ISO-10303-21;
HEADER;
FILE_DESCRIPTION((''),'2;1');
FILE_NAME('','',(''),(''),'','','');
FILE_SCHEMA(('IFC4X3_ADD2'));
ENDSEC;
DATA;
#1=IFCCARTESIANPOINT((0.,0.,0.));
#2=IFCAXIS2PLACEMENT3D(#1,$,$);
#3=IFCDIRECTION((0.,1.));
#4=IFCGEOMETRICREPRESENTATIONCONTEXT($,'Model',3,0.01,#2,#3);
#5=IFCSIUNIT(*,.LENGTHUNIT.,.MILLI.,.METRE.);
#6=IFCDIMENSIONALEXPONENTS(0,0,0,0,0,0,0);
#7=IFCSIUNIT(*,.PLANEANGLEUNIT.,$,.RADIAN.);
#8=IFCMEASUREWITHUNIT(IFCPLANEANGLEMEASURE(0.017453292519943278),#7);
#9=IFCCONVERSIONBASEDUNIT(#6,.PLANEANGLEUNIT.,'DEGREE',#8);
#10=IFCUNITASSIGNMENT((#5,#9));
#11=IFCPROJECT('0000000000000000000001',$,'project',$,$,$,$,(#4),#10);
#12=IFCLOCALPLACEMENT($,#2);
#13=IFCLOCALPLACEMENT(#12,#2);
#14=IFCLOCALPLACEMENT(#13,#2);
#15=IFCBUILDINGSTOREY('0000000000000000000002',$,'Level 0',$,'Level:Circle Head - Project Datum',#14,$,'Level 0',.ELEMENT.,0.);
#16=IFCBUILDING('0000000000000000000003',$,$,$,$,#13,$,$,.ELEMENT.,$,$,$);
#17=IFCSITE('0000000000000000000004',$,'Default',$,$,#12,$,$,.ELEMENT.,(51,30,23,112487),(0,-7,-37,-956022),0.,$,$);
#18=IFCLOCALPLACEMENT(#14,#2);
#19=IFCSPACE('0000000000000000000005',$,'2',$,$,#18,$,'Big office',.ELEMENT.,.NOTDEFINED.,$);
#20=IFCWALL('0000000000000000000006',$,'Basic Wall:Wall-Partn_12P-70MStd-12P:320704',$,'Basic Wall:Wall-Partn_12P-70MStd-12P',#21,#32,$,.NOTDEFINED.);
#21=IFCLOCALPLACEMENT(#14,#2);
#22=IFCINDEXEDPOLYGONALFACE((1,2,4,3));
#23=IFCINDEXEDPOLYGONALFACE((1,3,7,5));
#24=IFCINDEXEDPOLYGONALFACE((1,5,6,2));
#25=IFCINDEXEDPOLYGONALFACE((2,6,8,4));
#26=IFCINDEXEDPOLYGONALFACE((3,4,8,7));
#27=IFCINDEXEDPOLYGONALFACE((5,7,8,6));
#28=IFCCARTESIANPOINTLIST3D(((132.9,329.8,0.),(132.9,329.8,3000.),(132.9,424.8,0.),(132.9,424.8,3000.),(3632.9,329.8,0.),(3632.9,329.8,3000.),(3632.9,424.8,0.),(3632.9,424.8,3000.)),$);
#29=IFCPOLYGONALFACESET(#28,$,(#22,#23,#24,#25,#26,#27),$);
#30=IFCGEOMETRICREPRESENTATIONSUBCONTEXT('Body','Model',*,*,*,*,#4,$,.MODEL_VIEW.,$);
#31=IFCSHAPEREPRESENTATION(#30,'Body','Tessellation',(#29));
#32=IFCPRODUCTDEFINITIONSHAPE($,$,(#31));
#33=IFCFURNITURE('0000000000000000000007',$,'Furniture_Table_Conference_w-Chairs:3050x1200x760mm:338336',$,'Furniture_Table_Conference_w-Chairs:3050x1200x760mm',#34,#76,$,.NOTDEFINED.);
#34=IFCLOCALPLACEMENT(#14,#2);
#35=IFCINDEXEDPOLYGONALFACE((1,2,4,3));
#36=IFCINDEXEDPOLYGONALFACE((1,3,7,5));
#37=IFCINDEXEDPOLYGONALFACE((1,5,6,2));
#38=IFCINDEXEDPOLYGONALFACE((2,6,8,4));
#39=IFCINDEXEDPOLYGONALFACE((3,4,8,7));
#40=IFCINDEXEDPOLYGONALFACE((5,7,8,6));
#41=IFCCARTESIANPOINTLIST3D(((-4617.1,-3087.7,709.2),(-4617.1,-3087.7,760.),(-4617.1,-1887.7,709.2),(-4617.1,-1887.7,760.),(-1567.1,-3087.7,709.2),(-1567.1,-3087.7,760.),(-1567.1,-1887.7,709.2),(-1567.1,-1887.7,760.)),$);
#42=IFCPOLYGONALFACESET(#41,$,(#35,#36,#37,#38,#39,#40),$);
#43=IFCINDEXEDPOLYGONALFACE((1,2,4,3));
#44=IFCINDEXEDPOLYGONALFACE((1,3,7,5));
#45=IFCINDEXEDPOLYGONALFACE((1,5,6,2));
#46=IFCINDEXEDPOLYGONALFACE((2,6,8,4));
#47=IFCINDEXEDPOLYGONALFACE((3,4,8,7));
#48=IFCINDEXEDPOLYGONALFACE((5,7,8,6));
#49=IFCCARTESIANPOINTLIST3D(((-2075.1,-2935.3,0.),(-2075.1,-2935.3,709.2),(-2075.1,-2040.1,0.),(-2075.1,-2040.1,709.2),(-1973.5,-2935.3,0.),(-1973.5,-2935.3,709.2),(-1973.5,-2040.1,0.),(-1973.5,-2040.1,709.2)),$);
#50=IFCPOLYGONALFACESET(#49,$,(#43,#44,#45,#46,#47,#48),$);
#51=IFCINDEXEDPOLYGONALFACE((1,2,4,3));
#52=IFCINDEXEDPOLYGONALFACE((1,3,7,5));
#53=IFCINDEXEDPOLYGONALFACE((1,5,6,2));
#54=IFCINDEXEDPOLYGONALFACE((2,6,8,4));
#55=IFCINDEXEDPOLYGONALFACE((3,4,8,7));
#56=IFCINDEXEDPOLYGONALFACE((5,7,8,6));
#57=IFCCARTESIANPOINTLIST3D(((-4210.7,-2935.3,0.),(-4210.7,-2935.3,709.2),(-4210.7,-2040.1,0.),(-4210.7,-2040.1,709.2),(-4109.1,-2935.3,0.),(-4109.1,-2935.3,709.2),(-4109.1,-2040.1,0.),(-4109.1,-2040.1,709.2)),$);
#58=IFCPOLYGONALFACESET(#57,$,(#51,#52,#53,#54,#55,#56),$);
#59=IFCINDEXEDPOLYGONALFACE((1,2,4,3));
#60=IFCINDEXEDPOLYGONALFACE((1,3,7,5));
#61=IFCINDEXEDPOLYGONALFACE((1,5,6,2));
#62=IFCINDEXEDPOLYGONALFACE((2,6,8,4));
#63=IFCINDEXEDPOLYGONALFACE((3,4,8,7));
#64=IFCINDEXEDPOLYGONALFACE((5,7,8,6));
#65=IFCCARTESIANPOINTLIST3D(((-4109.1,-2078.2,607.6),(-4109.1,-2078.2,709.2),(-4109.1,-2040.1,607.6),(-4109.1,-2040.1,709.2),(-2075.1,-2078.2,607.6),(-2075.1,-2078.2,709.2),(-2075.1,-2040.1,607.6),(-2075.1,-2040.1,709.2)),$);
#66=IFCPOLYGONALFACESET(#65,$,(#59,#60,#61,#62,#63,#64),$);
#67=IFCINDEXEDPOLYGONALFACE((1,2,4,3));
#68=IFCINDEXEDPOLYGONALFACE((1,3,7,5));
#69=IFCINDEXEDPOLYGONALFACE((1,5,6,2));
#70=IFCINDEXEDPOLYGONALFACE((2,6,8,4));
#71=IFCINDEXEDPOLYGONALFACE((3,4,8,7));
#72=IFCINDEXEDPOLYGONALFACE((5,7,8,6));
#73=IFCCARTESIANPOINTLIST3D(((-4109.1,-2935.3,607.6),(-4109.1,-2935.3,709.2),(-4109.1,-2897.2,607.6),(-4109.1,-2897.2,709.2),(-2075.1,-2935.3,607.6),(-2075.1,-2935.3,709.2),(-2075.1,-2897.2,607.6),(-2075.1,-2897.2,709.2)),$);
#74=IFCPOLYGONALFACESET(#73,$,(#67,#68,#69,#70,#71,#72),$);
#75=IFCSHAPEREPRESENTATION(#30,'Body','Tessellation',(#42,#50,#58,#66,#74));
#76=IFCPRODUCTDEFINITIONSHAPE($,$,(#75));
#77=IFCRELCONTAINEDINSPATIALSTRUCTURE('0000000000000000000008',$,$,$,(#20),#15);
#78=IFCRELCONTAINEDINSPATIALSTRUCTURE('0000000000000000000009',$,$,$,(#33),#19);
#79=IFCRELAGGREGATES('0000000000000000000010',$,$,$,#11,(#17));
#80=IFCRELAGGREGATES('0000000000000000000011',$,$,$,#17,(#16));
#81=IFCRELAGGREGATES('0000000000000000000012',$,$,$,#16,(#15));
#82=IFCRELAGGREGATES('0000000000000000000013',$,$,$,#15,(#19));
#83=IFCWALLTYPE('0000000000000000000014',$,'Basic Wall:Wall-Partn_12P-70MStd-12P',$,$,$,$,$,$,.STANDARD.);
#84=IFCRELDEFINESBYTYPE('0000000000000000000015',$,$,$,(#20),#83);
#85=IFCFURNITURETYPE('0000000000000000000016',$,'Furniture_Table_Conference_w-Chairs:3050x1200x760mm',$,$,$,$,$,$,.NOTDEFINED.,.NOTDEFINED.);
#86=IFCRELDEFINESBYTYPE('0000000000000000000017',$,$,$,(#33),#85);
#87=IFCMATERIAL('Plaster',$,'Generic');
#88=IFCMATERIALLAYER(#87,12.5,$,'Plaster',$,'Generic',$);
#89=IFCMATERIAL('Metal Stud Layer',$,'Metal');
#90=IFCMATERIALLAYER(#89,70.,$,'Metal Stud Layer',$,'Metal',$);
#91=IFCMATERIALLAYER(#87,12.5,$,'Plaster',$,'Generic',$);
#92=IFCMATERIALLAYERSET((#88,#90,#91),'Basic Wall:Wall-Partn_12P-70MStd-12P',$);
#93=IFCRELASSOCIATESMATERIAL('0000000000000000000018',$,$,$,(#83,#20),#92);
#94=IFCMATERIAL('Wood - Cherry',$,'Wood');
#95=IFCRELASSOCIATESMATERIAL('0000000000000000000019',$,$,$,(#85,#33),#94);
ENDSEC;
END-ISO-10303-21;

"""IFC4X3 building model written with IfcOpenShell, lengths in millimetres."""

from ifc_helpers import new_model, entity, si_unit, converted_unit, direction, frame, frame_2d, origin, origin_2d_with_axis, place, context, subcontext, project, spatial, rectangle, extrude, source, transform, mapped, material, layer, layer_set, type_object, type_shapes, element, save


model = new_model("IFC4X3")

# Units and contexts
model_context = context("Model", 3, precision=0.01, world=origin(), true_north=direction((0.0, 1.0)))
body_context = subcontext(model_context, "Body", "Model", "MODEL_VIEW")
ifc_project = project(units=[si_unit("LENGTHUNIT", "METRE", prefix="MILLI"), converted_unit("PLANEANGLEUNIT", "DEGREE", entity("IfcPlaneAngleMeasure", 0.017453292519943278), si_unit("PLANEANGLEUNIT", "RADIAN"), dimensions=[0, 0, 0, 0, 0, 0, 0])], contexts=[model_context])

# Site, building, storey
site_placement = place(None, origin())
site = spatial("IfcSite", under=ifc_project, at=site_placement, Name="Default", CompositionType="ELEMENT", RefLatitude=(51, 30, 23, 112487), RefLongitude=(0, -7, -37, -956022), RefElevation=0.0)
building_placement = place(site_placement, origin())
building = spatial("IfcBuilding", under=site, at=building_placement, CompositionType="ELEMENT")
storey_placement = place(building_placement, origin())
storey = spatial("IfcBuildingStorey", under=building, at=storey_placement, Name="Level 0", ObjectType="Level:Circle Head - Project Datum", LongName="Level 0", CompositionType="ELEMENT", Elevation=0.0)

# Shared definitions
ifc_material_1 = material(Name="Plaster", Category="Generic")

# Shared definitions
ifc_material_2 = material(Name="Metal Stud Layer", Category="Metal")

# Shared definitions
ifc_layer_1 = layer(ifc_material_1, 12.5, Name="Plaster", Category="Generic")
ifc_layer_2 = layer(ifc_material_2, 70.0, Name="Metal Stud Layer", Category="Metal")
ifc_layer_3 = layer(ifc_material_1, 12.5, Name="Plaster", Category="Generic")
ifc_layer_set_1 = layer_set([ifc_layer_1, ifc_layer_2, ifc_layer_3], Name="Basic Wall:Wall-Partn_12P-70MStd-12P")
wall_type_1 = type_object("IfcWallType", Name="Basic Wall:Wall-Partn_12P-70MStd-12P", PredefinedType="STANDARD", material=ifc_layer_set_1)

# Wall
wall_1_placement = place(storey_placement, frame((132.9, 377.3, 0.0)))
element("IfcWall", 1, at=wall_1_placement, inside=storey, type_object=wall_type_1, material=ifc_layer_set_1, Name="Basic Wall:Wall-Partn_12P-70MStd-12P:320704", ObjectType="Basic Wall:Wall-Partn_12P-70MStd-12P", PredefinedType="NOTDEFINED", context=body_context, shape_type="SweptSolid", body=[
    extrude(rectangle(XDim=3500.0, YDim=95.0, at=frame_2d((1750.0, 0.0), x_axis=(-1.0, 0.0))), origin(), (0.0, 0.0, 1.0), 3000.0),
])

# Shared definitions
space_1_placement = place(storey_placement, origin())
space_1 = spatial("IfcSpace", under=storey, at=space_1_placement, Name="2", LongName="Big office", CompositionType="ELEMENT", PredefinedType="NOTDEFINED")

# Furniture
ifc_material_3 = material(Name="Wood - Cherry", Category="Wood")
furniture_type_1 = type_object("IfcFurnitureType", Name="Furniture_Table_Conference_w-Chairs:3050x1200x760mm", AssemblyPlace="NOTDEFINED", PredefinedType="NOTDEFINED", material=ifc_material_3)
shared_shape_1 = source(origin(), body_context, "Body", "SweptSolid", [
    extrude(rectangle(XDim=1200.0, YDim=3050.0, at=origin_2d_with_axis()), frame((0.0, 0.0, 709.2), z_axis=(0.0, 0.0, 1.0), x_axis=(0.0, 1.0, 0.0)), (0.0, 0.0, 1.0), 50.8),
    extrude(rectangle(XDim=895.2, YDim=101.6, at=origin_2d_with_axis()), frame((1067.8, 0.0, 0.0), z_axis=(0.0, 0.0, 1.0), x_axis=(0.0, 1.0, 0.0)), (0.0, 0.0, 1.0), 709.2),
    extrude(rectangle(XDim=895.2, YDim=101.6, at=frame_2d((0.0, 0.0), x_axis=(1.0, 0.0))), frame((-1067.8, 0.0, 0.0), z_axis=(0.0, 0.0, 1.0), x_axis=(0.0, 1.0, 0.0)), (0.0, 0.0, 1.0), 709.2),
    extrude(rectangle(XDim=2034.0, YDim=38.1, at=origin_2d_with_axis()), frame((0.0, 428.6, 607.6), z_axis=(0.0, 0.0, 1.0), x_axis=(-1.0, 0.0, 0.0)), (0.0, 0.0, 1.0), 101.6),
    extrude(rectangle(XDim=38.1, YDim=2034.0, at=origin_2d_with_axis()), frame((0.0, -428.6, 607.6), z_axis=(0.0, 0.0, 1.0), x_axis=(0.0, 1.0, 0.0)), (0.0, 0.0, 1.0), 101.6),
])
type_shapes(furniture_type_1, [shared_shape_1])
furniture_1_placement = place(space_1_placement, frame((-3092.1, -2487.7, 0.0)))
element("IfcFurniture", 2, at=furniture_1_placement, inside=space_1, type_object=furniture_type_1, material=ifc_material_3, Name="Furniture_Table_Conference_w-Chairs:3050x1200x760mm:338336", ObjectType="Furniture_Table_Conference_w-Chairs:3050x1200x760mm", PredefinedType="NOTDEFINED", context=body_context, shape_type="MappedRepresentation", body=[
    mapped(shared_shape_1, transform((0.0, 0.0, 0.0), scale=1.0)),
])

save(model, "model.ifc")
